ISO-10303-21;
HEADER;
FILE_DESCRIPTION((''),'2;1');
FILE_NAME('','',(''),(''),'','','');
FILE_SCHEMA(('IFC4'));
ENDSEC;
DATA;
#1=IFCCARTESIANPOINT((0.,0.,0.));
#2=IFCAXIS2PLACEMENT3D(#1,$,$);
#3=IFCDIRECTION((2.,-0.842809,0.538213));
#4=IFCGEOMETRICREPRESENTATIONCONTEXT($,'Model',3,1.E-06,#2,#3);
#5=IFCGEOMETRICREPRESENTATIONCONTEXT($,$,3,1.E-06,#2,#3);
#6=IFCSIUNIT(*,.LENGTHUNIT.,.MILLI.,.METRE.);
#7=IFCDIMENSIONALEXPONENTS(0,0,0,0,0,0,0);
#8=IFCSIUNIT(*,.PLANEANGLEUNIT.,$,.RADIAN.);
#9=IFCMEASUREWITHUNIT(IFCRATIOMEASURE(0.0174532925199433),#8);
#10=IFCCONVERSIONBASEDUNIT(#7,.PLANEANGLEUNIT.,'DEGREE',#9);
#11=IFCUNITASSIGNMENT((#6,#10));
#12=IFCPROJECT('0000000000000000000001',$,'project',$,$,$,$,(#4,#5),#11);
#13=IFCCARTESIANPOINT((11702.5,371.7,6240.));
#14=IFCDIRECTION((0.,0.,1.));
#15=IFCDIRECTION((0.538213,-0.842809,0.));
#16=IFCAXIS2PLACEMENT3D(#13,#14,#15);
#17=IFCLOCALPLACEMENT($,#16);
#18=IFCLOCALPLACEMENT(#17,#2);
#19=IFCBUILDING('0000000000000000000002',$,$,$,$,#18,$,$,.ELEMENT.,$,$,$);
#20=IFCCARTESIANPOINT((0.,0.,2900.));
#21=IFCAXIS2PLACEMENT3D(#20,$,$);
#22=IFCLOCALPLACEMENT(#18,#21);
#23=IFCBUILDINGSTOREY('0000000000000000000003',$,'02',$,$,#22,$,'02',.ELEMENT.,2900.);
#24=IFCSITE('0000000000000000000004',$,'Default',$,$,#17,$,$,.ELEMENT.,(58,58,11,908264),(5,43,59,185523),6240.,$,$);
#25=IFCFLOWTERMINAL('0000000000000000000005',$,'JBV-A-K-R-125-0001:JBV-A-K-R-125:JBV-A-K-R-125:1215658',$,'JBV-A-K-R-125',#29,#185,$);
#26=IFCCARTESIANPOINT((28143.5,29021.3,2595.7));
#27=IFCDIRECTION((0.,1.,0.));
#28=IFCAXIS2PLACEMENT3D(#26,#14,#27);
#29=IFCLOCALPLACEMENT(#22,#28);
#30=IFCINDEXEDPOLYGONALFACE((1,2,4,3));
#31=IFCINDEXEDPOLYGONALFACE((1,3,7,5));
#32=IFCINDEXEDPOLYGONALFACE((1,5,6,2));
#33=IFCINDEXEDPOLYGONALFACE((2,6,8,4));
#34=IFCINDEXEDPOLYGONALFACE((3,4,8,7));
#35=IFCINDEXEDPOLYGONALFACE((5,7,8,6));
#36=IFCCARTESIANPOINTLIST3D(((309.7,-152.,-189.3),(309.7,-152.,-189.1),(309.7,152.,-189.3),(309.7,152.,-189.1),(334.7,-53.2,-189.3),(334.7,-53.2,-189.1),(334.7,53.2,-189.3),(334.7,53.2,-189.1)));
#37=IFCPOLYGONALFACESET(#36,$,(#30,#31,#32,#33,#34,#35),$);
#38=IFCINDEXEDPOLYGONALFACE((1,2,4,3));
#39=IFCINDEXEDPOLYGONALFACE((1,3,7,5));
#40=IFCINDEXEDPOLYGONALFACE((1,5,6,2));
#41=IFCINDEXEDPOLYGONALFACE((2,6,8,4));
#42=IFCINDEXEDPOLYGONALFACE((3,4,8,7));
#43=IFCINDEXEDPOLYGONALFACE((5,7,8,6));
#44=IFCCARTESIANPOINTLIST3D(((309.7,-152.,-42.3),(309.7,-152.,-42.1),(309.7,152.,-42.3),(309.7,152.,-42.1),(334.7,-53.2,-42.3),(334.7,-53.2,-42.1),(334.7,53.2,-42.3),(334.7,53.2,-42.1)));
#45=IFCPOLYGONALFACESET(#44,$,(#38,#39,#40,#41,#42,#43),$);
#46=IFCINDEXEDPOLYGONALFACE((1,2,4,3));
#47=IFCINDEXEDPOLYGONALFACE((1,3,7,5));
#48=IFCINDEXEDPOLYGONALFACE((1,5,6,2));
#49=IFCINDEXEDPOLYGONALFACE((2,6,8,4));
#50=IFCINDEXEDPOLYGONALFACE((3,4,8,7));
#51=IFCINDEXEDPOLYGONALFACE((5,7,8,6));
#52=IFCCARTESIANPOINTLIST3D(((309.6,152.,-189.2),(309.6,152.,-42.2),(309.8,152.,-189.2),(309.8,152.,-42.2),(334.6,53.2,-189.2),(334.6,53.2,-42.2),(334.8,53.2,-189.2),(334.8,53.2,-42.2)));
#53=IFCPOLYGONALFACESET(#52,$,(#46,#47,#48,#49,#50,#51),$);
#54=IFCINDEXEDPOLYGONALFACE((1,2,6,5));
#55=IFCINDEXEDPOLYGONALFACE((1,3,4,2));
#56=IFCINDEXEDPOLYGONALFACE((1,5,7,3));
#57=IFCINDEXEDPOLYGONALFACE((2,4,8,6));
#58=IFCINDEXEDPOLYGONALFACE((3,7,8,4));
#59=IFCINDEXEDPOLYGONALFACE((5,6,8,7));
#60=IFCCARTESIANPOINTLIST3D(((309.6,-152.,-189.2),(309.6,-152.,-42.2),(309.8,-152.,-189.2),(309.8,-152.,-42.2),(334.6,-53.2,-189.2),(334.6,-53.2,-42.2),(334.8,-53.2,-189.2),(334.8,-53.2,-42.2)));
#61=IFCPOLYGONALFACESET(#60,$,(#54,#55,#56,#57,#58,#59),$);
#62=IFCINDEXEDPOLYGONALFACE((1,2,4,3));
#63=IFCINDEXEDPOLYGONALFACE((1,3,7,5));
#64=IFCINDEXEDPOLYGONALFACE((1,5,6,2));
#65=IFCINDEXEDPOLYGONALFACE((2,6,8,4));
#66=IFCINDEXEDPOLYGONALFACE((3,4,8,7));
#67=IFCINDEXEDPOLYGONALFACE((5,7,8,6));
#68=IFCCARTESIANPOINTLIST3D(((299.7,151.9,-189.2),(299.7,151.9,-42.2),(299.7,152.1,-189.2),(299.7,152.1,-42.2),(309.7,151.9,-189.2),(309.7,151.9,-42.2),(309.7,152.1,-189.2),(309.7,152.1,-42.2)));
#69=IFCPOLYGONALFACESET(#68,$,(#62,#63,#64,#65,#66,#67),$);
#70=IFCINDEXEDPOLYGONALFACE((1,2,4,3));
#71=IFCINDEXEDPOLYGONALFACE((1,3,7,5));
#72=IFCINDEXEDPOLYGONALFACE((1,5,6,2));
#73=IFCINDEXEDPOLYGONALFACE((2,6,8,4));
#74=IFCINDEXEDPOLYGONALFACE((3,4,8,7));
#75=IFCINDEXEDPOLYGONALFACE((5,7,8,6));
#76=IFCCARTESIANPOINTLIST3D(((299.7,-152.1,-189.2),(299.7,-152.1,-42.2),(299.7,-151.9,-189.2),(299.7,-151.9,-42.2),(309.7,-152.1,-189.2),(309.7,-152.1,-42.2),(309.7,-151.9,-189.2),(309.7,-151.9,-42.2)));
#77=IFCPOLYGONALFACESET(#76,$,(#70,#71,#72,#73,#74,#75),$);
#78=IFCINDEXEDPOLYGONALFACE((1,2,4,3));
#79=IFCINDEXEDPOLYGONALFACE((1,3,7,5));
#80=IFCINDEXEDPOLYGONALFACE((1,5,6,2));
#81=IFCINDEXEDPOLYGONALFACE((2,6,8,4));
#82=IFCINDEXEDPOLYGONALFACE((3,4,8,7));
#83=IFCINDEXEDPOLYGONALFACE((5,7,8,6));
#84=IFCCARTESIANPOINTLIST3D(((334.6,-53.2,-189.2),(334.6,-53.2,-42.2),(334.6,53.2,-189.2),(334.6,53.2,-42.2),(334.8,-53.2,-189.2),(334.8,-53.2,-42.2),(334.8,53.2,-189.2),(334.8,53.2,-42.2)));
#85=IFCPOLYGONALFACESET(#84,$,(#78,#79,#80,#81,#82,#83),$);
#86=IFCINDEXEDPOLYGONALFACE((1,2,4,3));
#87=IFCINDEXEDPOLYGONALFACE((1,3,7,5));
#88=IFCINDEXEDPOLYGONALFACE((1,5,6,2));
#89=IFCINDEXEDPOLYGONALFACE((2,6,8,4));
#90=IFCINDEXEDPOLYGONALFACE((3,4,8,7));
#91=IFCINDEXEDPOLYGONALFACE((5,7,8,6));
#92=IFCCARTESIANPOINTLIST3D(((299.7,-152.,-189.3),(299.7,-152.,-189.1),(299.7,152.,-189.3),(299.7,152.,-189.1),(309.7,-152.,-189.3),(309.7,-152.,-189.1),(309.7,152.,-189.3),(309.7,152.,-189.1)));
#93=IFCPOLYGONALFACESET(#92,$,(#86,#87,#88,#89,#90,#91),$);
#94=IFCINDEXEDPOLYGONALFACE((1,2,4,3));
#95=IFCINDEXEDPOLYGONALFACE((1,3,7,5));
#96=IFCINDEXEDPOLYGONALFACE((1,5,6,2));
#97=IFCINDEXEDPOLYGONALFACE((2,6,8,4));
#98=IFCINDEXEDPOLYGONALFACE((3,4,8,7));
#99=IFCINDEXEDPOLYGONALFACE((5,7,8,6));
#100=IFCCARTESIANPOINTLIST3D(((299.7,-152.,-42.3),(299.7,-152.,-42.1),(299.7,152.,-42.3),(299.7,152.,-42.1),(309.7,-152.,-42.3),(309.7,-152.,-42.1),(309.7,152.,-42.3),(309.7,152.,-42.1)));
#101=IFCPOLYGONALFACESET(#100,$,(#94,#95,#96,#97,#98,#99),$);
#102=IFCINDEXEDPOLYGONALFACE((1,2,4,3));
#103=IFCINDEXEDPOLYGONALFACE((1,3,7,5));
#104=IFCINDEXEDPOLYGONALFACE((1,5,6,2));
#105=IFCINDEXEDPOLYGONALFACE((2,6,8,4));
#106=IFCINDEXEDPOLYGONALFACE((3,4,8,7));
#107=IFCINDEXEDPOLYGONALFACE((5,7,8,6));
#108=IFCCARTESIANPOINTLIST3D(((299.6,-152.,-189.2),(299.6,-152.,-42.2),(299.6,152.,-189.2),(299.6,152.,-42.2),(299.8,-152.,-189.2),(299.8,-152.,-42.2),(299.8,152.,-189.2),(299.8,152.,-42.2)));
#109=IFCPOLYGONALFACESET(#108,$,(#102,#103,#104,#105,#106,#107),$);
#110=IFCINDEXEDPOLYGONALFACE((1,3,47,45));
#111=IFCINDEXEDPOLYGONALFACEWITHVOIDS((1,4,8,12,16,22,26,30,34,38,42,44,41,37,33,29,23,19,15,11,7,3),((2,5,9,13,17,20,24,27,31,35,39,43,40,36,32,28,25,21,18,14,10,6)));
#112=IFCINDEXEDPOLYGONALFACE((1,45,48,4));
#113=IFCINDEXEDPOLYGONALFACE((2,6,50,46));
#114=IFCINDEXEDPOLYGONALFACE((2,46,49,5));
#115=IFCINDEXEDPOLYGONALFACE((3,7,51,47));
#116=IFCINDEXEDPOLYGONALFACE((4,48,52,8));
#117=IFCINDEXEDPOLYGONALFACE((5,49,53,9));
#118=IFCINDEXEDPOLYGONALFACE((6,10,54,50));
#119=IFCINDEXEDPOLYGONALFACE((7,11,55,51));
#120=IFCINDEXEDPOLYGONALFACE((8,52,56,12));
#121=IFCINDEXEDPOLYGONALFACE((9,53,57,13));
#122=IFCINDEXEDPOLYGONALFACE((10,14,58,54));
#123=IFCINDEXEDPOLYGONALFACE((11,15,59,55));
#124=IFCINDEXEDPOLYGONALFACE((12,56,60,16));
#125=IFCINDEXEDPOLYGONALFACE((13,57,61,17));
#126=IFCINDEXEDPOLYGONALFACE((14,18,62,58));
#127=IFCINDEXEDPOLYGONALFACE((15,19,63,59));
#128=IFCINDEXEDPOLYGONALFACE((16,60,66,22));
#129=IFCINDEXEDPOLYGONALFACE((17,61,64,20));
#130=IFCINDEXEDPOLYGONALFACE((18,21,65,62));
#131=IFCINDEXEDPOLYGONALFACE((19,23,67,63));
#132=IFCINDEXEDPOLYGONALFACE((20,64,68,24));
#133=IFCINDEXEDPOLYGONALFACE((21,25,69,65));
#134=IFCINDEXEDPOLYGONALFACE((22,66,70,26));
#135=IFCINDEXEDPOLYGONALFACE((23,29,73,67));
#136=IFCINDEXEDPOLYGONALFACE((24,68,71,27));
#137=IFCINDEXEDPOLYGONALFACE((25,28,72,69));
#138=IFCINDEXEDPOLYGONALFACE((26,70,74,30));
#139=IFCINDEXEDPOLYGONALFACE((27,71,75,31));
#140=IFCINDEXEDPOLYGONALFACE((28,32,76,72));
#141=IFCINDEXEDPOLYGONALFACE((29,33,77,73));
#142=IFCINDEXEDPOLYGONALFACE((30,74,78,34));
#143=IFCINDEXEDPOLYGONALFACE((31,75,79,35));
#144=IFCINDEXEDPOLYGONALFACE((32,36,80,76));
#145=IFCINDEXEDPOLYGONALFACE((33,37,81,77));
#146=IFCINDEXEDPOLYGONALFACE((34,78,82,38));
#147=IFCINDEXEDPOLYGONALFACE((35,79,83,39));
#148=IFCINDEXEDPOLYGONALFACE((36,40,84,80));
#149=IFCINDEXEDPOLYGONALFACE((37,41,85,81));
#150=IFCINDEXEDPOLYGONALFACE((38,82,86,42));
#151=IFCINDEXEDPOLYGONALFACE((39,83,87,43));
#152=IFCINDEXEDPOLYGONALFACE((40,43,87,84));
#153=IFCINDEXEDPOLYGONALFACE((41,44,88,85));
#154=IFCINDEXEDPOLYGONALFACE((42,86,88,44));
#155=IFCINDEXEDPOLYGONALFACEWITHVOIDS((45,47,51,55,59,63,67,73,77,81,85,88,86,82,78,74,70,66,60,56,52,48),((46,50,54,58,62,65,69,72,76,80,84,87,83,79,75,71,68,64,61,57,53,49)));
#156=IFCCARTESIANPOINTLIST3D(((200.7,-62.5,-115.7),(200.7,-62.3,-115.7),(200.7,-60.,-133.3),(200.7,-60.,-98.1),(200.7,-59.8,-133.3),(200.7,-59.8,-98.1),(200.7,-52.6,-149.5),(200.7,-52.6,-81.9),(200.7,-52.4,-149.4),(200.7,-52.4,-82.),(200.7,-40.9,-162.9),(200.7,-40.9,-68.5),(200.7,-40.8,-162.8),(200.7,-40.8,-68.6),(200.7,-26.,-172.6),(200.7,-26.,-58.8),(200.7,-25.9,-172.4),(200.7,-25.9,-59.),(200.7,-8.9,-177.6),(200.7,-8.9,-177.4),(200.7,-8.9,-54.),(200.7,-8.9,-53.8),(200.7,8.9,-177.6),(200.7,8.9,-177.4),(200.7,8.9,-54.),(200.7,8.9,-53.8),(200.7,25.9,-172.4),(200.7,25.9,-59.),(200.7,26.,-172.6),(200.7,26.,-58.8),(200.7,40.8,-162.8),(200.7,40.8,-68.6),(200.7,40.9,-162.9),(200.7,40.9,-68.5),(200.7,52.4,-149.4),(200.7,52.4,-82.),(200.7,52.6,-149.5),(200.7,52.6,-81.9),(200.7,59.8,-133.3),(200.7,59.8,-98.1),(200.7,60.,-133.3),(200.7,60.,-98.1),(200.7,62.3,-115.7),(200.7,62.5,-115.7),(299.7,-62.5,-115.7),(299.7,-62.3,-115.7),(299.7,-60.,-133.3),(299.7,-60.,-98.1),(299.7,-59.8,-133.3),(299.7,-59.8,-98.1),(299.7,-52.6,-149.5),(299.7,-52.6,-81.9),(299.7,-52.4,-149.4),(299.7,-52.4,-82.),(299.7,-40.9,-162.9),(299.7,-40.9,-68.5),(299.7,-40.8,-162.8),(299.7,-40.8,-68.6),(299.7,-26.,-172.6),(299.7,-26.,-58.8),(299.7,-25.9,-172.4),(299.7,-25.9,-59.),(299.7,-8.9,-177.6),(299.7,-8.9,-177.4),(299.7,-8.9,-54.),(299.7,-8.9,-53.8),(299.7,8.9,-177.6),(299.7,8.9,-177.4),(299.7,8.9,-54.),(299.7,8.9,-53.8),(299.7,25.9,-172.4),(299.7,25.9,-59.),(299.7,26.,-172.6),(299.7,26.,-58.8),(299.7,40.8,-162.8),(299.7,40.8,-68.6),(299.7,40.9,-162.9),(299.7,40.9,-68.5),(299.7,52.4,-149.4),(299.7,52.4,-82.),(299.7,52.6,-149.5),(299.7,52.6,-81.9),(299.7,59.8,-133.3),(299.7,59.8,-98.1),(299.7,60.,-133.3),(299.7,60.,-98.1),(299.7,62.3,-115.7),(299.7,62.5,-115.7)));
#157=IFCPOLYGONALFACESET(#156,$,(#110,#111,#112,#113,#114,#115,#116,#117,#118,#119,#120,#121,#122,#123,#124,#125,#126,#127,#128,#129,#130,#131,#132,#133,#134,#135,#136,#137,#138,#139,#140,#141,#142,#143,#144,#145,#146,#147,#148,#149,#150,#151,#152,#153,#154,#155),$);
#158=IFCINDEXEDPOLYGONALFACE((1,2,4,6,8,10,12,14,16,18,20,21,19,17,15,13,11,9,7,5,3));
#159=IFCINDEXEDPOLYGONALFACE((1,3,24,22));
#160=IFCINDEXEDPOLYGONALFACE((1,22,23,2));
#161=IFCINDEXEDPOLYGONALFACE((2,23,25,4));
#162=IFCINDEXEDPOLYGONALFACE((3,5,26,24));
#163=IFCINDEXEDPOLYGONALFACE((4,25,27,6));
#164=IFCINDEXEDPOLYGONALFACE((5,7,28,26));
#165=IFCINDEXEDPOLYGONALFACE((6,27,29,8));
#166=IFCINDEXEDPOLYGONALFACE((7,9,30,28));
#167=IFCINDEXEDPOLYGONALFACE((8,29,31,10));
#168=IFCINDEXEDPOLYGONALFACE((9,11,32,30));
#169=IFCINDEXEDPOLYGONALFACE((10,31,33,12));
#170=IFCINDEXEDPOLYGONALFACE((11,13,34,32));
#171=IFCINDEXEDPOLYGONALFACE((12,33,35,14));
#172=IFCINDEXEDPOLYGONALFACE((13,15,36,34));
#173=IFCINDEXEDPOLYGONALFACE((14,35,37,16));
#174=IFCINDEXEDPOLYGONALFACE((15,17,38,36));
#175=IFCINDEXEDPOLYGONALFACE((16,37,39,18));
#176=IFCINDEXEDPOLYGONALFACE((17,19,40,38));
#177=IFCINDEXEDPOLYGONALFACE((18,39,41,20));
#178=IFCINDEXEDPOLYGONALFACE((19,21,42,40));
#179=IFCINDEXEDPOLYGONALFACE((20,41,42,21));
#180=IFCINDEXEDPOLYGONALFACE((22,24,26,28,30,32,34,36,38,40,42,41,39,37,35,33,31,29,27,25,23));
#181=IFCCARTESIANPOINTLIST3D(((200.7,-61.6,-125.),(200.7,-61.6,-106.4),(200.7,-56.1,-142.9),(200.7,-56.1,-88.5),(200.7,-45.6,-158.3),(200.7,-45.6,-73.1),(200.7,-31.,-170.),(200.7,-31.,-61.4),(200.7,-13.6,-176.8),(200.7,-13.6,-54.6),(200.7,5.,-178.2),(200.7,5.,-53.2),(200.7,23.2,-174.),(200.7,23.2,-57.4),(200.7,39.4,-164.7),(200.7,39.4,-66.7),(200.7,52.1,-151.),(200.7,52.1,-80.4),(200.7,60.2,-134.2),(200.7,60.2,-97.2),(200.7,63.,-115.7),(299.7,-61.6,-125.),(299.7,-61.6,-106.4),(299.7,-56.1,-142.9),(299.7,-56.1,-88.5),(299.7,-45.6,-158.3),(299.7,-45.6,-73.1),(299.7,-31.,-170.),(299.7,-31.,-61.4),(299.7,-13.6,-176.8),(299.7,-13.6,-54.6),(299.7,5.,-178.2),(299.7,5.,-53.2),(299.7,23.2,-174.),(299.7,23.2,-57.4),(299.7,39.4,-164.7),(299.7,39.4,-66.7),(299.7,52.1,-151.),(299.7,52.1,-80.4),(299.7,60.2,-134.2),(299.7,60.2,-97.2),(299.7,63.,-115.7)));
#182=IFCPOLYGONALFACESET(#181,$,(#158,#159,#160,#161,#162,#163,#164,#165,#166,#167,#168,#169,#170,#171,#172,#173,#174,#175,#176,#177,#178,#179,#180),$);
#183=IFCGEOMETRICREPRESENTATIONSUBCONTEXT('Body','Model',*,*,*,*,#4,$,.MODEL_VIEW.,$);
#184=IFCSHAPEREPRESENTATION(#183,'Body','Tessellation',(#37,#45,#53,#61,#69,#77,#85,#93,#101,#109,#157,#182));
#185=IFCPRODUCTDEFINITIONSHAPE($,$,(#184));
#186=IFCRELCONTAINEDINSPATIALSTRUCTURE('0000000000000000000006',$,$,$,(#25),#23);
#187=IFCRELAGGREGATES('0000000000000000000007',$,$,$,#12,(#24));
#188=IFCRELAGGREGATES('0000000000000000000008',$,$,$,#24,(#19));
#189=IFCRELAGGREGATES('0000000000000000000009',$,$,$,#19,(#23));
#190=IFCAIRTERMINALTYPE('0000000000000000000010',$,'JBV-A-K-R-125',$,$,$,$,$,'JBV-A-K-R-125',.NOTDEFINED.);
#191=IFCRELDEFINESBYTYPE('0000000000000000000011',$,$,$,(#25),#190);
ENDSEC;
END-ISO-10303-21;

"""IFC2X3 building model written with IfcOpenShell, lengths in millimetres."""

from ifc_helpers import new_model, entity, si_unit, converted_unit, direction, frame, frame_2d, origin, origin_2d_with_axis, place, context, subcontext, project, spatial, polyline, circle_curve, parameter, trimmed, segment, composite_curve, rectangle, circle, outline, extrude, source, transform, mapped, type_object, type_shapes, element, save


model = new_model("IFC2X3")

# Units and contexts
model_context = context("Model", 3, precision=1e-06, world=origin(), true_north=direction((2.0, -0.842809, 0.538213)))
context_of_model = context(None, 3, precision=1e-06, world=origin(), true_north=direction((2.0, -0.842809, 0.538213)))
body_context = subcontext(model_context, "Body", "Model", "MODEL_VIEW")
ifc_project = project(units=[si_unit("LENGTHUNIT", "METRE", prefix="MILLI"), converted_unit("PLANEANGLEUNIT", "DEGREE", entity("IfcRatioMeasure", 0.0174532925199433), si_unit("PLANEANGLEUNIT", "RADIAN"), dimensions=[0, 0, 0, 0, 0, 0, 0])], contexts=[model_context, context_of_model])

# Site, building, storey
site_placement = place(None, frame((11702.5, 371.7, 6240.0), z_axis=(0.0, 0.0, 1.0), x_axis=(0.538213, -0.842809, 0.0)))
site = spatial("IfcSite", under=ifc_project, at=site_placement, Name="Default", CompositionType="ELEMENT", RefLatitude=(58, 58, 11, 908264), RefLongitude=(5, 43, 59, 185523), RefElevation=6240.0)
building_placement = place(site_placement, origin())
building = spatial("IfcBuilding", under=site, at=building_placement, CompositionType="ELEMENT")
storey_placement = place(building_placement, frame((0.0, 0.0, 2900.0)))
storey = spatial("IfcBuildingStorey", under=building, at=storey_placement, Name="02", LongName="02", CompositionType="ELEMENT", Elevation=2900.0)

# Flow terminal
air_terminal_type_1 = type_object("IfcAirTerminalType", Name="JBV-A-K-R-125", ElementType="JBV-A-K-R-125", PredefinedType="NOTDEFINED")
shared_shape_1 = source(origin(), body_context, "Body", "SweptSolid", [
    extrude(outline(polyline([(-152.0, -12.5), (152.0, -12.5), (53.2, 12.5), (-53.2, 12.5), (-152.0, -12.5)])), frame((322.2, 0.0, -189.3), z_axis=(0.0, 0.0, 1.0), x_axis=(0.0, -1.0, 0.0)), (0.0, 0.0, 1.0), 0.2),
    extrude(outline(polyline([(-152.0, -12.5), (152.0, -12.5), (53.2, 12.5), (-53.2, 12.5), (-152.0, -12.5)])), frame((322.2, 0.0, -42.3), z_axis=(0.0, 0.0, 1.0), x_axis=(0.0, -1.0, 0.0)), (0.0, 0.0, 1.0), 0.2),
    extrude(rectangle(XDim=0.2, YDim=101.9, at=frame_2d((0.0, 0.0), x_axis=(1.0, 0.0))), frame((322.2, 102.6, -189.2), z_axis=(0.0, 0.0, 1.0), x_axis=(0.969446, 0.245305, 0.0)), (0.0, 0.0, 1.0), 147.0),
    extrude(rectangle(XDim=0.2, YDim=101.9, at=frame_2d((0.0, 0.0), x_axis=(1.0, 0.0))), frame((322.2, -102.6, -189.2), z_axis=(0.0, 0.0, 1.0), x_axis=(-0.969446, 0.245305, 0.0)), (0.0, 0.0, 1.0), 147.0),
    extrude(rectangle(XDim=0.2, YDim=10.0, at=frame_2d((0.0, 0.0), x_axis=(1.0, 0.0))), frame((304.7, 152.0, -189.2), z_axis=(0.0, 0.0, 1.0), x_axis=(0.0, 1.0, 0.0)), (0.0, 0.0, 1.0), 147.0),
    extrude(rectangle(XDim=0.2, YDim=10.0, at=frame_2d((0.0, 0.0), x_axis=(1.0, 0.0))), frame((304.7, -152.0, -189.2), z_axis=(0.0, 0.0, 1.0), x_axis=(0.0, 1.0, 0.0)), (0.0, 0.0, 1.0), 147.0),
    extrude(rectangle(XDim=0.2, YDim=106.4, at=frame_2d((0.0, 0.0), x_axis=(1.0, 0.0))), frame((334.7, 0.0, -189.2)), (0.0, 0.0, 1.0), 147.0),
    extrude(rectangle(XDim=304.0, YDim=10.0, at=frame_2d((0.0, 0.0), x_axis=(1.0, 0.0))), frame((304.7, 0.0, -189.3), z_axis=(0.0, 0.0, 1.0), x_axis=(0.0, -1.0, 0.0)), (0.0, 0.0, 1.0), 0.2),
    extrude(rectangle(XDim=304.0, YDim=10.0, at=frame_2d((0.0, 0.0), x_axis=(1.0, 0.0))), frame((304.7, 0.0, -42.3), z_axis=(0.0, 0.0, 1.0), x_axis=(0.0, -1.0, 0.0)), (0.0, 0.0, 1.0), 0.2),
    extrude(rectangle(XDim=0.2, YDim=304.0, at=frame_2d((0.0, 0.0), x_axis=(1.0, 0.0))), frame((299.7, 0.0, -189.2)), (0.0, 0.0, 1.0), 147.0),
    extrude(outline(composite_curve([segment(trimmed(circle_curve(origin_2d_with_axis(), 62.5), [parameter(0.0)], [parameter(180.0)], True, "PARAMETER"), True, "CONTINUOUS"), segment(trimmed(circle_curve(origin_2d_with_axis(), 62.5), [parameter(180.0)], [parameter(360.0)], True, "PARAMETER"), True, "CONTINUOUS")], self_intersect=False), holes=[composite_curve([segment(trimmed(circle_curve(origin_2d_with_axis(), 62.3), [parameter(180.0)], [parameter(360.0)], True, "PARAMETER"), False, "CONTINUOUS"), segment(trimmed(circle_curve(origin_2d_with_axis(), 62.3), [parameter(0.0)], [parameter(180.0)], True, "PARAMETER"), False, "CONTINUOUS")], self_intersect=False)]), frame((200.7, 0.0, -115.7), z_axis=(1.0, 0.0, 0.0), x_axis=(0.0, 1.0, 0.0)), (0.0, 0.0, 1.0), 99.0),
    extrude(circle(Radius=62.6, at=frame_2d((0.0, 0.0), x_axis=(1.0, 0.0))), frame((200.7, 0.3, -115.7), z_axis=(1.0, 0.0, 0.0), x_axis=(0.0, 1.0, 0.0)), (0.0, 0.0, 1.0), 99.0),
])
type_shapes(air_terminal_type_1, [shared_shape_1])
flow_terminal_1_placement = place(storey_placement, frame((28143.5, 29021.3, 2595.7), z_axis=(0.0, 0.0, 1.0), x_axis=(0.0, 1.0, 0.0)))
element("IfcFlowTerminal", 1, at=flow_terminal_1_placement, inside=storey, type_object=air_terminal_type_1, Name="JBV-A-K-R-125-0001:JBV-A-K-R-125:JBV-A-K-R-125:1215658", ObjectType="JBV-A-K-R-125", context=body_context, shape_type="MappedRepresentation", body=[
    mapped(shared_shape_1, transform((0.0, 0.0, 0.0), scale=1.0)),
])

save(model, "model.ifc")
